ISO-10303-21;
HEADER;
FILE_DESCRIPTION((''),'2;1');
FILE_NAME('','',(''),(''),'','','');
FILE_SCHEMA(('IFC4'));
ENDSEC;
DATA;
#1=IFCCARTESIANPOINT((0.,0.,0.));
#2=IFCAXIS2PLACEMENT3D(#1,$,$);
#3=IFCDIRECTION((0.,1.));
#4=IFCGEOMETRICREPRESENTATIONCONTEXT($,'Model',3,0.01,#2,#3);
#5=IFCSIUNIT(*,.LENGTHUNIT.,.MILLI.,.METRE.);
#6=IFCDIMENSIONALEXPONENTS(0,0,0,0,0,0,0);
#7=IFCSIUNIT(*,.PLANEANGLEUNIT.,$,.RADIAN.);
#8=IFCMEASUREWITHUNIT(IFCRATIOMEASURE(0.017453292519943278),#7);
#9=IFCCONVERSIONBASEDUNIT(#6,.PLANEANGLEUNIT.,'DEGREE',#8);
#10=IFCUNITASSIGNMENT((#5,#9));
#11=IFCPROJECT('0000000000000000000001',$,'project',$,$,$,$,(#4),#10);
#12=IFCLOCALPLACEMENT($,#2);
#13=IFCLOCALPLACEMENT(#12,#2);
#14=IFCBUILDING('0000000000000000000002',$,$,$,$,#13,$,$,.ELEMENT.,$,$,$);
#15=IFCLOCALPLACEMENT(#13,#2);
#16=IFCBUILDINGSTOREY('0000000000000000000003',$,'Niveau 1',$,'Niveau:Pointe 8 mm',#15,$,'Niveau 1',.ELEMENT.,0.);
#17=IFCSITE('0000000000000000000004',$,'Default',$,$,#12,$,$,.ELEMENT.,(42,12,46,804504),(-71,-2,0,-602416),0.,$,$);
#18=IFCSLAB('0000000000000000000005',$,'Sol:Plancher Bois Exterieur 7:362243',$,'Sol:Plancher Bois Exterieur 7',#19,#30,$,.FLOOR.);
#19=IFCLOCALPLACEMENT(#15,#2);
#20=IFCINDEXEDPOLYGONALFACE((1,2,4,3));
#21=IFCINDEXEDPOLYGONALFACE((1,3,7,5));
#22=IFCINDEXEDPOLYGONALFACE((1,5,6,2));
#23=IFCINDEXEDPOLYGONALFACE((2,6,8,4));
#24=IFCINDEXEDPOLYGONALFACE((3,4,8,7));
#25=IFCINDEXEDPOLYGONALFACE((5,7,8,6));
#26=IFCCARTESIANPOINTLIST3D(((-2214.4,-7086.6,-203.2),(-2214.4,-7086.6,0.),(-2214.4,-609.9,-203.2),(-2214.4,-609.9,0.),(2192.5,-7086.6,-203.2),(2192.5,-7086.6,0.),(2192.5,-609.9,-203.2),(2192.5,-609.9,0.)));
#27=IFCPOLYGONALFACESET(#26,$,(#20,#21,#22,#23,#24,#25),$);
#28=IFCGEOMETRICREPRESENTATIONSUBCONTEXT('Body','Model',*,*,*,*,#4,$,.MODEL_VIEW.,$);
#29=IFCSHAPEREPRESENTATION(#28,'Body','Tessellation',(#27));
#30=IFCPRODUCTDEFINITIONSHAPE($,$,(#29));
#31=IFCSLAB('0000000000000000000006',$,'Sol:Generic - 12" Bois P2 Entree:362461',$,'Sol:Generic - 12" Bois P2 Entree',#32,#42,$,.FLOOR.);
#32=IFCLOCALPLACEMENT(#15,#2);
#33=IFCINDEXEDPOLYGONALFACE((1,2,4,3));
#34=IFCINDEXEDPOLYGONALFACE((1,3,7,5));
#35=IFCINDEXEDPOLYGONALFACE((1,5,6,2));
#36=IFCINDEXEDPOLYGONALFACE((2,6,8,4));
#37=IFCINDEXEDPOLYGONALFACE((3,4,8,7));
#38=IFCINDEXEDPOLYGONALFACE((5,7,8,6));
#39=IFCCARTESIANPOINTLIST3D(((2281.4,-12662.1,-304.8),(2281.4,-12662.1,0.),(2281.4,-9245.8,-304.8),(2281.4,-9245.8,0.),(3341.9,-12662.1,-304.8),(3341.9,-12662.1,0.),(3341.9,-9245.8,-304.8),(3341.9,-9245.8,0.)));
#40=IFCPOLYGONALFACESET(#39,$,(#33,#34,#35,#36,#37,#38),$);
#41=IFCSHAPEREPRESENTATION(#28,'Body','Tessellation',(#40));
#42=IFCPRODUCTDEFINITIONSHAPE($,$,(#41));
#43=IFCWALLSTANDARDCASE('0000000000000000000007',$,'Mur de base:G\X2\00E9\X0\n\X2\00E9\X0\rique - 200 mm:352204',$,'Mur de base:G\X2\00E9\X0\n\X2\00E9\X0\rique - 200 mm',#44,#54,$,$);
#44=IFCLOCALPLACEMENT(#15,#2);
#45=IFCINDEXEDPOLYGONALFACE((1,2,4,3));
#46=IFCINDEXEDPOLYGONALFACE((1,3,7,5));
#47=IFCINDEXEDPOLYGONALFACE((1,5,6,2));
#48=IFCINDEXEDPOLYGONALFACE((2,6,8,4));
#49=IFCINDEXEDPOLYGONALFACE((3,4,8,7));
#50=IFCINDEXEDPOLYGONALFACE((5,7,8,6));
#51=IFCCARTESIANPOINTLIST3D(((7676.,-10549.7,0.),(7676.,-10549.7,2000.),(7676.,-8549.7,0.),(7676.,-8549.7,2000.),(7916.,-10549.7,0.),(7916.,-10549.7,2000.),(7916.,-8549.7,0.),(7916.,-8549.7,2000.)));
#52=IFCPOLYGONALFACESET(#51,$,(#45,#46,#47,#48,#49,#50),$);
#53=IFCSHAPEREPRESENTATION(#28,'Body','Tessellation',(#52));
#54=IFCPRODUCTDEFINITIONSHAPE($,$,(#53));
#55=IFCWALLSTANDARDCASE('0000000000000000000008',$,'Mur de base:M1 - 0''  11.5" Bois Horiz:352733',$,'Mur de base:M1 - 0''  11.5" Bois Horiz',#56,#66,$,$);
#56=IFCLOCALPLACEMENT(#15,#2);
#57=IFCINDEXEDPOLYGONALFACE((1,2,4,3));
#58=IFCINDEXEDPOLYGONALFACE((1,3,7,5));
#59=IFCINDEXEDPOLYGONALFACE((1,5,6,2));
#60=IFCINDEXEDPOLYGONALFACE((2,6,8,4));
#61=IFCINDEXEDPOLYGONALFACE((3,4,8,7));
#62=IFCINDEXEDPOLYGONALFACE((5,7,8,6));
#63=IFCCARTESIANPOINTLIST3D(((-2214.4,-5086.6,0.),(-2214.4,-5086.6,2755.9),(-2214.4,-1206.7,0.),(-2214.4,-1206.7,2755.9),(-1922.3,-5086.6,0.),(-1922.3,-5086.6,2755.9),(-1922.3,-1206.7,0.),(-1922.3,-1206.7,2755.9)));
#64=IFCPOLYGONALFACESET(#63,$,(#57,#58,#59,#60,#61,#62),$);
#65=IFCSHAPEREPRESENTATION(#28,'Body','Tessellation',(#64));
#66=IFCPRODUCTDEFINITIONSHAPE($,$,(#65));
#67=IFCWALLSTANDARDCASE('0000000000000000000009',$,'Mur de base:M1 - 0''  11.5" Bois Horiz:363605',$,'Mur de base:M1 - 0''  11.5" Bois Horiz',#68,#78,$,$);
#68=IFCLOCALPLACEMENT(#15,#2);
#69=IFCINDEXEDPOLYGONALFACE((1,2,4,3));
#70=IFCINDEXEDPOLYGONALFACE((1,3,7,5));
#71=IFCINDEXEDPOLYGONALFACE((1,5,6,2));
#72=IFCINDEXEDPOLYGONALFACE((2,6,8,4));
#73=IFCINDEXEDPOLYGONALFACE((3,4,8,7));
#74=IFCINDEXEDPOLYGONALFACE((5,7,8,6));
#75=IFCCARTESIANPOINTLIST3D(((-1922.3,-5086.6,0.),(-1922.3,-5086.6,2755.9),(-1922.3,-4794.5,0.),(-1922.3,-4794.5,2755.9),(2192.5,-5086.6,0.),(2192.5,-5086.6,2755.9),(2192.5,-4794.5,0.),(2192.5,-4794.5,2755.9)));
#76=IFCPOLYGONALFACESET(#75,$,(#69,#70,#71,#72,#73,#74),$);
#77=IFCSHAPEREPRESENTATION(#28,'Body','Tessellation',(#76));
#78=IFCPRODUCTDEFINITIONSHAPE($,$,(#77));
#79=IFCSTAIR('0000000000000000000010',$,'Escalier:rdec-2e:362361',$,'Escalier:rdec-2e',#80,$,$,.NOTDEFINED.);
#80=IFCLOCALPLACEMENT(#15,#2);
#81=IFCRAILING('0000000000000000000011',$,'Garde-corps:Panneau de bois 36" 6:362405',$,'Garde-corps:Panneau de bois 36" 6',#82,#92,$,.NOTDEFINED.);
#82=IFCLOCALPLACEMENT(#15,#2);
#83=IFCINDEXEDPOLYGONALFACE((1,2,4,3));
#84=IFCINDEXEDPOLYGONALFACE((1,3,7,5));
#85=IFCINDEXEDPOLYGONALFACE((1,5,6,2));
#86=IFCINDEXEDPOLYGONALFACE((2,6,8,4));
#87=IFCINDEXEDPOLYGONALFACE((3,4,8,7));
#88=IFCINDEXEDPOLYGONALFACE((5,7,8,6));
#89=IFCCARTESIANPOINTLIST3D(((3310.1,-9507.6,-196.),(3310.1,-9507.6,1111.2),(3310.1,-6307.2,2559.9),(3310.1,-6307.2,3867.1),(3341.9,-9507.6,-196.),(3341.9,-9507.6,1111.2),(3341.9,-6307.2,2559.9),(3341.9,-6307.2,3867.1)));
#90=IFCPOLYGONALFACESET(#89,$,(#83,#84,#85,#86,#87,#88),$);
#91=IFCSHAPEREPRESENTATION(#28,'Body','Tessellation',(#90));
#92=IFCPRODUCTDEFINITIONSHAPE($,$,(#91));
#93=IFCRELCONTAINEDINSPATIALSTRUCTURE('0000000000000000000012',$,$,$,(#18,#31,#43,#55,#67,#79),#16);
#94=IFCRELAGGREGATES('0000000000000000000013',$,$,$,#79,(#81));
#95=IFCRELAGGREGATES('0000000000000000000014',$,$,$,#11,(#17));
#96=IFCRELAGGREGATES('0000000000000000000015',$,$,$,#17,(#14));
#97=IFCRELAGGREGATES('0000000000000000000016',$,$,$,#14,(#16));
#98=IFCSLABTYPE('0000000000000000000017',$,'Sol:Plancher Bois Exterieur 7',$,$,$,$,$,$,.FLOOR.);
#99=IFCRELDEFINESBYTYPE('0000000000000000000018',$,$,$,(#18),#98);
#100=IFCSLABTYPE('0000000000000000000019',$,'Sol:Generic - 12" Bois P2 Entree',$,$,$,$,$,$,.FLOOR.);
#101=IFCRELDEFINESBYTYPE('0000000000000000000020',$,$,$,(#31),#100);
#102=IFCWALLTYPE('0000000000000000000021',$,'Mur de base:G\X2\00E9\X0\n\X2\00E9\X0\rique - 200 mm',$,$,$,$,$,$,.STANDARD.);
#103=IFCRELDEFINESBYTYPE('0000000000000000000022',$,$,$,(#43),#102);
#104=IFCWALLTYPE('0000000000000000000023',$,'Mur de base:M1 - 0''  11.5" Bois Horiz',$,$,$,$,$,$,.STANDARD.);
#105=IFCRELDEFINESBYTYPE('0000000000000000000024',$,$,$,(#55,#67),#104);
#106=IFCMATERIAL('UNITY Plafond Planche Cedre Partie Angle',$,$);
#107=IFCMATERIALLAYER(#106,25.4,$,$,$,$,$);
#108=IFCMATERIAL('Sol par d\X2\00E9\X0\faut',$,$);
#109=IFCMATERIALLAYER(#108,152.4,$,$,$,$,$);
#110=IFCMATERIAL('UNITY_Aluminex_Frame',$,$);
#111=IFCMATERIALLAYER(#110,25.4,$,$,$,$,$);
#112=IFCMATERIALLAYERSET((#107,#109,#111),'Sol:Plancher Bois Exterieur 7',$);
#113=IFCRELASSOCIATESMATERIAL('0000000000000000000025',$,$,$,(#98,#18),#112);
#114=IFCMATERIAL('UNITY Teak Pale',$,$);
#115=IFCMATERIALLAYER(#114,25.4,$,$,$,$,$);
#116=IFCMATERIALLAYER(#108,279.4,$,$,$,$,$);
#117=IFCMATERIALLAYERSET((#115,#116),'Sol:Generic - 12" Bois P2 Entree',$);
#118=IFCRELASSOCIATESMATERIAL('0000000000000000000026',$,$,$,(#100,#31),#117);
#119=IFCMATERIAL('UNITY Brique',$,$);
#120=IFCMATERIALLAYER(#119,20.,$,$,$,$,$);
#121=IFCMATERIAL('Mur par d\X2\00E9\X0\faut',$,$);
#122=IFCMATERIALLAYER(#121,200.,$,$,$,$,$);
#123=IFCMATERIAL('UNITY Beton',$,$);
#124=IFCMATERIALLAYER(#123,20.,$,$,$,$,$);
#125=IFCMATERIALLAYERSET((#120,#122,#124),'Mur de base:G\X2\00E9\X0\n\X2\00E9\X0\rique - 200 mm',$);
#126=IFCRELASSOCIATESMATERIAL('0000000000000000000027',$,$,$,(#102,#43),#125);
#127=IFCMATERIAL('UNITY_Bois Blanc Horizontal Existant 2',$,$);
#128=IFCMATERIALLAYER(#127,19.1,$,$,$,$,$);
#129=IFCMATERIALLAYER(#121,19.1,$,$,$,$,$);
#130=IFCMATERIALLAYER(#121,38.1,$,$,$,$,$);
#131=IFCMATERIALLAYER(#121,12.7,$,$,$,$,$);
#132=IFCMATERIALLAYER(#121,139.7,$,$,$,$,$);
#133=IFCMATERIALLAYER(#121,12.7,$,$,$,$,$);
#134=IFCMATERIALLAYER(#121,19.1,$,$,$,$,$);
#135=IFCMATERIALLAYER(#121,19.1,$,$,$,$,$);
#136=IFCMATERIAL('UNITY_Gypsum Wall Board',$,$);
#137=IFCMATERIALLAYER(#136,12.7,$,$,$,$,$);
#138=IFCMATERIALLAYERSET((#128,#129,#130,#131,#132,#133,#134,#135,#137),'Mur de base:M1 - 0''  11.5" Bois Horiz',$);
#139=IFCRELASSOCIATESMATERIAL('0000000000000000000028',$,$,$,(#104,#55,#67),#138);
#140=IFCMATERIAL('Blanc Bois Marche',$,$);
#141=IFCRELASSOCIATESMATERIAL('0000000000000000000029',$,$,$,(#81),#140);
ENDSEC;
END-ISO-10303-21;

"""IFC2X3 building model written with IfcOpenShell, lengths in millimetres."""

from ifc_helpers import new_model, entity, si_unit, converted_unit, direction, frame, frame_2d, origin, place, context, subcontext, project, spatial, polyline, rectangle, outline, extrude, material, layer, layer_set, layer_usage, type_object, element, aggregate, save


model = new_model("IFC2X3")

# Units and contexts
model_context = context("Model", 3, precision=0.01, world=origin(), true_north=direction((0.0, 1.0)))
body_context = subcontext(model_context, "Body", "Model", "MODEL_VIEW")
ifc_project = project(units=[si_unit("LENGTHUNIT", "METRE", prefix="MILLI"), converted_unit("PLANEANGLEUNIT", "DEGREE", entity("IfcRatioMeasure", 0.017453292519943278), si_unit("PLANEANGLEUNIT", "RADIAN"), dimensions=[0, 0, 0, 0, 0, 0, 0])], contexts=[model_context])

# Site, building, storey
site_placement = place(None, origin())
site = spatial("IfcSite", under=ifc_project, at=site_placement, Name="Default", CompositionType="ELEMENT", RefLatitude=(42, 12, 46, 804504), RefLongitude=(-71, -2, 0, -602416), RefElevation=0.0)
building_placement = place(site_placement, origin())
building = spatial("IfcBuilding", under=site, at=building_placement, CompositionType="ELEMENT")
storey_placement = place(building_placement, origin())
storey = spatial("IfcBuildingStorey", under=building, at=storey_placement, Name="Niveau 1", ObjectType="Niveau:Pointe 8 mm", LongName="Niveau 1", CompositionType="ELEMENT", Elevation=0.0)

# Slabs
ifc_material_1 = material(Name="UNITY Plafond Planche Cedre Partie Angle")
ifc_layer_1 = layer(ifc_material_1, 25.4)
ifc_material_2 = material(Name="Sol par défaut")
ifc_layer_2 = layer(ifc_material_2, 152.4)
ifc_material_3 = material(Name="UNITY_Aluminex_Frame")
ifc_layer_3 = layer(ifc_material_3, 25.4)
ifc_layer_set_1 = layer_set([ifc_layer_1, ifc_layer_2, ifc_layer_3], Name="Sol:Plancher Bois Exterieur 7")
ifc_layer_usage_1 = layer_usage(ifc_layer_set_1, "AXIS3", "POSITIVE", 0.0)
slab_type_1 = type_object("IfcSlabType", Name="Sol:Plancher Bois Exterieur 7", PredefinedType="FLOOR", material=ifc_layer_set_1)
slab_1_placement = place(storey_placement, origin())
element("IfcSlab", 1, at=slab_1_placement, inside=storey, type_object=slab_type_1, material=ifc_layer_usage_1, Name="Sol:Plancher Bois Exterieur 7:362243", ObjectType="Sol:Plancher Bois Exterieur 7", PredefinedType="FLOOR", context=body_context, shape_type="SweptSolid", body=[
    extrude(rectangle(XDim=6476.6, YDim=4406.9, at=frame_2d((0.0, 0.0), x_axis=(1.0, 0.0))), frame((-10.9, -3848.2, 0.0), z_axis=(0.0, 0.0, -1.0), x_axis=(0.0, 1.0, 0.0)), (0.0, 0.0, 1.0), 203.2),
])
ifc_material_4 = material(Name="UNITY Teak Pale")
ifc_layer_4 = layer(ifc_material_4, 25.4)
ifc_layer_5 = layer(ifc_material_2, 279.4)
ifc_layer_set_2 = layer_set([ifc_layer_4, ifc_layer_5], Name="Sol:Generic - 12\" Bois P2 Entree")
ifc_layer_usage_2 = layer_usage(ifc_layer_set_2, "AXIS3", "POSITIVE", 0.0)
slab_type_2 = type_object("IfcSlabType", Name="Sol:Generic - 12\" Bois P2 Entree", PredefinedType="FLOOR", material=ifc_layer_set_2)
slab_2_placement = place(storey_placement, origin())
element("IfcSlab", 2, at=slab_2_placement, inside=storey, type_object=slab_type_2, material=ifc_layer_usage_2, Name="Sol:Generic - 12\" Bois P2 Entree:362461", ObjectType="Sol:Generic - 12\" Bois P2 Entree", PredefinedType="FLOOR", context=body_context, shape_type="SweptSolid", body=[
    extrude(rectangle(XDim=3416.3, YDim=1060.5, at=frame_2d((0.0, 0.0), x_axis=(1.0, 0.0))), frame((2811.6, -10954.0, 0.0), z_axis=(0.0, 0.0, -1.0), x_axis=(0.0, 1.0, 0.0)), (0.0, 0.0, 1.0), 304.8),
])

# Walls
ifc_material_5 = material(Name="UNITY Brique")
ifc_layer_6 = layer(ifc_material_5, 20.0)
ifc_material_6 = material(Name="Mur par défaut")
ifc_layer_7 = layer(ifc_material_6, 200.0)
ifc_material_7 = material(Name="UNITY Beton")
ifc_layer_8 = layer(ifc_material_7, 20.0)
ifc_layer_set_3 = layer_set([ifc_layer_6, ifc_layer_7, ifc_layer_8], Name="Mur de base:Générique - 200 mm")
ifc_layer_usage_3 = layer_usage(ifc_layer_set_3, "AXIS2", "NEGATIVE", 120.0)
wall_type_1 = type_object("IfcWallType", Name="Mur de base:Générique - 200 mm", PredefinedType="STANDARD", material=ifc_layer_set_3)
wall_1_placement = place(storey_placement, frame((7796.0, -8549.7, 0.0), z_axis=(0.0, 0.0, 1.0), x_axis=(0.0, -1.0, 0.0)))
element("IfcWallStandardCase", 3, at=wall_1_placement, inside=storey, type_object=wall_type_1, material=ifc_layer_usage_3, Name="Mur de base:Générique - 200 mm:352204", ObjectType="Mur de base:Générique - 200 mm", context=body_context, shape_type="SweptSolid", body=[
    extrude(rectangle(XDim=2000.0, YDim=240.0, at=frame_2d((1000.0, 0.0), x_axis=(-1.0, 0.0))), origin(), (0.0, 0.0, 1.0), 2000.0),
])
ifc_material_8 = material(Name="UNITY_Bois Blanc Horizontal Existant 2")
ifc_layer_9 = layer(ifc_material_8, 19.1)
ifc_layer_10 = layer(ifc_material_6, 19.1)
ifc_layer_11 = layer(ifc_material_6, 38.1)
ifc_layer_12 = layer(ifc_material_6, 12.7)
ifc_layer_13 = layer(ifc_material_6, 139.7)
ifc_layer_14 = layer(ifc_material_6, 12.7)
ifc_layer_15 = layer(ifc_material_6, 19.1)
ifc_layer_16 = layer(ifc_material_6, 19.1)
ifc_material_9 = material(Name="UNITY_Gypsum Wall Board")
ifc_layer_17 = layer(ifc_material_9, 12.7)
ifc_layer_set_4 = layer_set([ifc_layer_9, ifc_layer_10, ifc_layer_11, ifc_layer_12, ifc_layer_13, ifc_layer_14, ifc_layer_15, ifc_layer_16, ifc_layer_17], Name="Mur de base:M1 - 0'  11.5\" Bois Horiz")
ifc_layer_usage_4 = layer_usage(ifc_layer_set_4, "AXIS2", "NEGATIVE", 146.1)
wall_type_2 = type_object("IfcWallType", Name="Mur de base:M1 - 0'  11.5\" Bois Horiz", PredefinedType="STANDARD", material=ifc_layer_set_4)
wall_2_placement = place(storey_placement, frame((-2068.3, -5086.6, 0.0), z_axis=(0.0, 0.0, 1.0), x_axis=(0.0, 1.0, 0.0)))
element("IfcWallStandardCase", 4, at=wall_2_placement, inside=storey, type_object=wall_type_2, material=ifc_layer_usage_4, Name="Mur de base:M1 - 0'  11.5\" Bois Horiz:352733", ObjectType="Mur de base:M1 - 0'  11.5\" Bois Horiz", context=body_context, shape_type="SweptSolid", body=[
    extrude(rectangle(XDim=3879.8, YDim=292.1, at=frame_2d((1939.9, 0.0), x_axis=(-1.0, 0.0))), origin(), (0.0, 0.0, 1.0), 2755.9),
])
ifc_layer_usage_5 = layer_usage(ifc_layer_set_4, "AXIS2", "NEGATIVE", 146.1)
wall_3_placement = place(storey_placement, frame((2192.5, -4940.5, 0.0), z_axis=(0.0, 0.0, 1.0), x_axis=(-1.0, 0.0, 0.0)))
element("IfcWallStandardCase", 5, at=wall_3_placement, inside=storey, type_object=wall_type_2, material=ifc_layer_usage_5, Name="Mur de base:M1 - 0'  11.5\" Bois Horiz:363605", ObjectType="Mur de base:M1 - 0'  11.5\" Bois Horiz", context=body_context, shape_type="SweptSolid", body=[
    extrude(rectangle(XDim=4114.8, YDim=292.1, at=frame_2d((2057.4, 0.0), x_axis=(-1.0, 0.0))), origin(), (0.0, 0.0, 1.0), 2755.9),
])

# Stair, railing
stair_1_placement = place(storey_placement, origin())
stair_1 = element("IfcStair", 6, at=stair_1_placement, inside=storey, Name="Escalier:rdec-2e:362361", ObjectType="Escalier:rdec-2e", ShapeType="NOTDEFINED")
ifc_material_10 = material(Name="Blanc Bois Marche")
railing_placement = place(stair_1_placement, frame((0.0, 0.0, 4000.0)))
railing = element("IfcRailing", 7, at=railing_placement, material=ifc_material_10, Name="Garde-corps:Panneau de bois 36\" 6:362405", ObjectType="Garde-corps:Panneau de bois 36\" 6", PredefinedType="NOTDEFINED", context=body_context, shape_type="SweptSolid", body=[
    extrude(outline(polyline([(-2538.2, -495.3), (1685.2, -495.3), (2538.2, 495.3), (-1685.2, 495.3), (-2538.2, -495.3)])), frame((3310.1, -7907.4, -2164.4), z_axis=(1.0, 0.0, 0.0), x_axis=(0.0, -0.757769, -0.652523)), (0.0, 0.0, 1.0), 31.8),
])
aggregate(stair_1, [railing])

save(model, "model.ifc")
